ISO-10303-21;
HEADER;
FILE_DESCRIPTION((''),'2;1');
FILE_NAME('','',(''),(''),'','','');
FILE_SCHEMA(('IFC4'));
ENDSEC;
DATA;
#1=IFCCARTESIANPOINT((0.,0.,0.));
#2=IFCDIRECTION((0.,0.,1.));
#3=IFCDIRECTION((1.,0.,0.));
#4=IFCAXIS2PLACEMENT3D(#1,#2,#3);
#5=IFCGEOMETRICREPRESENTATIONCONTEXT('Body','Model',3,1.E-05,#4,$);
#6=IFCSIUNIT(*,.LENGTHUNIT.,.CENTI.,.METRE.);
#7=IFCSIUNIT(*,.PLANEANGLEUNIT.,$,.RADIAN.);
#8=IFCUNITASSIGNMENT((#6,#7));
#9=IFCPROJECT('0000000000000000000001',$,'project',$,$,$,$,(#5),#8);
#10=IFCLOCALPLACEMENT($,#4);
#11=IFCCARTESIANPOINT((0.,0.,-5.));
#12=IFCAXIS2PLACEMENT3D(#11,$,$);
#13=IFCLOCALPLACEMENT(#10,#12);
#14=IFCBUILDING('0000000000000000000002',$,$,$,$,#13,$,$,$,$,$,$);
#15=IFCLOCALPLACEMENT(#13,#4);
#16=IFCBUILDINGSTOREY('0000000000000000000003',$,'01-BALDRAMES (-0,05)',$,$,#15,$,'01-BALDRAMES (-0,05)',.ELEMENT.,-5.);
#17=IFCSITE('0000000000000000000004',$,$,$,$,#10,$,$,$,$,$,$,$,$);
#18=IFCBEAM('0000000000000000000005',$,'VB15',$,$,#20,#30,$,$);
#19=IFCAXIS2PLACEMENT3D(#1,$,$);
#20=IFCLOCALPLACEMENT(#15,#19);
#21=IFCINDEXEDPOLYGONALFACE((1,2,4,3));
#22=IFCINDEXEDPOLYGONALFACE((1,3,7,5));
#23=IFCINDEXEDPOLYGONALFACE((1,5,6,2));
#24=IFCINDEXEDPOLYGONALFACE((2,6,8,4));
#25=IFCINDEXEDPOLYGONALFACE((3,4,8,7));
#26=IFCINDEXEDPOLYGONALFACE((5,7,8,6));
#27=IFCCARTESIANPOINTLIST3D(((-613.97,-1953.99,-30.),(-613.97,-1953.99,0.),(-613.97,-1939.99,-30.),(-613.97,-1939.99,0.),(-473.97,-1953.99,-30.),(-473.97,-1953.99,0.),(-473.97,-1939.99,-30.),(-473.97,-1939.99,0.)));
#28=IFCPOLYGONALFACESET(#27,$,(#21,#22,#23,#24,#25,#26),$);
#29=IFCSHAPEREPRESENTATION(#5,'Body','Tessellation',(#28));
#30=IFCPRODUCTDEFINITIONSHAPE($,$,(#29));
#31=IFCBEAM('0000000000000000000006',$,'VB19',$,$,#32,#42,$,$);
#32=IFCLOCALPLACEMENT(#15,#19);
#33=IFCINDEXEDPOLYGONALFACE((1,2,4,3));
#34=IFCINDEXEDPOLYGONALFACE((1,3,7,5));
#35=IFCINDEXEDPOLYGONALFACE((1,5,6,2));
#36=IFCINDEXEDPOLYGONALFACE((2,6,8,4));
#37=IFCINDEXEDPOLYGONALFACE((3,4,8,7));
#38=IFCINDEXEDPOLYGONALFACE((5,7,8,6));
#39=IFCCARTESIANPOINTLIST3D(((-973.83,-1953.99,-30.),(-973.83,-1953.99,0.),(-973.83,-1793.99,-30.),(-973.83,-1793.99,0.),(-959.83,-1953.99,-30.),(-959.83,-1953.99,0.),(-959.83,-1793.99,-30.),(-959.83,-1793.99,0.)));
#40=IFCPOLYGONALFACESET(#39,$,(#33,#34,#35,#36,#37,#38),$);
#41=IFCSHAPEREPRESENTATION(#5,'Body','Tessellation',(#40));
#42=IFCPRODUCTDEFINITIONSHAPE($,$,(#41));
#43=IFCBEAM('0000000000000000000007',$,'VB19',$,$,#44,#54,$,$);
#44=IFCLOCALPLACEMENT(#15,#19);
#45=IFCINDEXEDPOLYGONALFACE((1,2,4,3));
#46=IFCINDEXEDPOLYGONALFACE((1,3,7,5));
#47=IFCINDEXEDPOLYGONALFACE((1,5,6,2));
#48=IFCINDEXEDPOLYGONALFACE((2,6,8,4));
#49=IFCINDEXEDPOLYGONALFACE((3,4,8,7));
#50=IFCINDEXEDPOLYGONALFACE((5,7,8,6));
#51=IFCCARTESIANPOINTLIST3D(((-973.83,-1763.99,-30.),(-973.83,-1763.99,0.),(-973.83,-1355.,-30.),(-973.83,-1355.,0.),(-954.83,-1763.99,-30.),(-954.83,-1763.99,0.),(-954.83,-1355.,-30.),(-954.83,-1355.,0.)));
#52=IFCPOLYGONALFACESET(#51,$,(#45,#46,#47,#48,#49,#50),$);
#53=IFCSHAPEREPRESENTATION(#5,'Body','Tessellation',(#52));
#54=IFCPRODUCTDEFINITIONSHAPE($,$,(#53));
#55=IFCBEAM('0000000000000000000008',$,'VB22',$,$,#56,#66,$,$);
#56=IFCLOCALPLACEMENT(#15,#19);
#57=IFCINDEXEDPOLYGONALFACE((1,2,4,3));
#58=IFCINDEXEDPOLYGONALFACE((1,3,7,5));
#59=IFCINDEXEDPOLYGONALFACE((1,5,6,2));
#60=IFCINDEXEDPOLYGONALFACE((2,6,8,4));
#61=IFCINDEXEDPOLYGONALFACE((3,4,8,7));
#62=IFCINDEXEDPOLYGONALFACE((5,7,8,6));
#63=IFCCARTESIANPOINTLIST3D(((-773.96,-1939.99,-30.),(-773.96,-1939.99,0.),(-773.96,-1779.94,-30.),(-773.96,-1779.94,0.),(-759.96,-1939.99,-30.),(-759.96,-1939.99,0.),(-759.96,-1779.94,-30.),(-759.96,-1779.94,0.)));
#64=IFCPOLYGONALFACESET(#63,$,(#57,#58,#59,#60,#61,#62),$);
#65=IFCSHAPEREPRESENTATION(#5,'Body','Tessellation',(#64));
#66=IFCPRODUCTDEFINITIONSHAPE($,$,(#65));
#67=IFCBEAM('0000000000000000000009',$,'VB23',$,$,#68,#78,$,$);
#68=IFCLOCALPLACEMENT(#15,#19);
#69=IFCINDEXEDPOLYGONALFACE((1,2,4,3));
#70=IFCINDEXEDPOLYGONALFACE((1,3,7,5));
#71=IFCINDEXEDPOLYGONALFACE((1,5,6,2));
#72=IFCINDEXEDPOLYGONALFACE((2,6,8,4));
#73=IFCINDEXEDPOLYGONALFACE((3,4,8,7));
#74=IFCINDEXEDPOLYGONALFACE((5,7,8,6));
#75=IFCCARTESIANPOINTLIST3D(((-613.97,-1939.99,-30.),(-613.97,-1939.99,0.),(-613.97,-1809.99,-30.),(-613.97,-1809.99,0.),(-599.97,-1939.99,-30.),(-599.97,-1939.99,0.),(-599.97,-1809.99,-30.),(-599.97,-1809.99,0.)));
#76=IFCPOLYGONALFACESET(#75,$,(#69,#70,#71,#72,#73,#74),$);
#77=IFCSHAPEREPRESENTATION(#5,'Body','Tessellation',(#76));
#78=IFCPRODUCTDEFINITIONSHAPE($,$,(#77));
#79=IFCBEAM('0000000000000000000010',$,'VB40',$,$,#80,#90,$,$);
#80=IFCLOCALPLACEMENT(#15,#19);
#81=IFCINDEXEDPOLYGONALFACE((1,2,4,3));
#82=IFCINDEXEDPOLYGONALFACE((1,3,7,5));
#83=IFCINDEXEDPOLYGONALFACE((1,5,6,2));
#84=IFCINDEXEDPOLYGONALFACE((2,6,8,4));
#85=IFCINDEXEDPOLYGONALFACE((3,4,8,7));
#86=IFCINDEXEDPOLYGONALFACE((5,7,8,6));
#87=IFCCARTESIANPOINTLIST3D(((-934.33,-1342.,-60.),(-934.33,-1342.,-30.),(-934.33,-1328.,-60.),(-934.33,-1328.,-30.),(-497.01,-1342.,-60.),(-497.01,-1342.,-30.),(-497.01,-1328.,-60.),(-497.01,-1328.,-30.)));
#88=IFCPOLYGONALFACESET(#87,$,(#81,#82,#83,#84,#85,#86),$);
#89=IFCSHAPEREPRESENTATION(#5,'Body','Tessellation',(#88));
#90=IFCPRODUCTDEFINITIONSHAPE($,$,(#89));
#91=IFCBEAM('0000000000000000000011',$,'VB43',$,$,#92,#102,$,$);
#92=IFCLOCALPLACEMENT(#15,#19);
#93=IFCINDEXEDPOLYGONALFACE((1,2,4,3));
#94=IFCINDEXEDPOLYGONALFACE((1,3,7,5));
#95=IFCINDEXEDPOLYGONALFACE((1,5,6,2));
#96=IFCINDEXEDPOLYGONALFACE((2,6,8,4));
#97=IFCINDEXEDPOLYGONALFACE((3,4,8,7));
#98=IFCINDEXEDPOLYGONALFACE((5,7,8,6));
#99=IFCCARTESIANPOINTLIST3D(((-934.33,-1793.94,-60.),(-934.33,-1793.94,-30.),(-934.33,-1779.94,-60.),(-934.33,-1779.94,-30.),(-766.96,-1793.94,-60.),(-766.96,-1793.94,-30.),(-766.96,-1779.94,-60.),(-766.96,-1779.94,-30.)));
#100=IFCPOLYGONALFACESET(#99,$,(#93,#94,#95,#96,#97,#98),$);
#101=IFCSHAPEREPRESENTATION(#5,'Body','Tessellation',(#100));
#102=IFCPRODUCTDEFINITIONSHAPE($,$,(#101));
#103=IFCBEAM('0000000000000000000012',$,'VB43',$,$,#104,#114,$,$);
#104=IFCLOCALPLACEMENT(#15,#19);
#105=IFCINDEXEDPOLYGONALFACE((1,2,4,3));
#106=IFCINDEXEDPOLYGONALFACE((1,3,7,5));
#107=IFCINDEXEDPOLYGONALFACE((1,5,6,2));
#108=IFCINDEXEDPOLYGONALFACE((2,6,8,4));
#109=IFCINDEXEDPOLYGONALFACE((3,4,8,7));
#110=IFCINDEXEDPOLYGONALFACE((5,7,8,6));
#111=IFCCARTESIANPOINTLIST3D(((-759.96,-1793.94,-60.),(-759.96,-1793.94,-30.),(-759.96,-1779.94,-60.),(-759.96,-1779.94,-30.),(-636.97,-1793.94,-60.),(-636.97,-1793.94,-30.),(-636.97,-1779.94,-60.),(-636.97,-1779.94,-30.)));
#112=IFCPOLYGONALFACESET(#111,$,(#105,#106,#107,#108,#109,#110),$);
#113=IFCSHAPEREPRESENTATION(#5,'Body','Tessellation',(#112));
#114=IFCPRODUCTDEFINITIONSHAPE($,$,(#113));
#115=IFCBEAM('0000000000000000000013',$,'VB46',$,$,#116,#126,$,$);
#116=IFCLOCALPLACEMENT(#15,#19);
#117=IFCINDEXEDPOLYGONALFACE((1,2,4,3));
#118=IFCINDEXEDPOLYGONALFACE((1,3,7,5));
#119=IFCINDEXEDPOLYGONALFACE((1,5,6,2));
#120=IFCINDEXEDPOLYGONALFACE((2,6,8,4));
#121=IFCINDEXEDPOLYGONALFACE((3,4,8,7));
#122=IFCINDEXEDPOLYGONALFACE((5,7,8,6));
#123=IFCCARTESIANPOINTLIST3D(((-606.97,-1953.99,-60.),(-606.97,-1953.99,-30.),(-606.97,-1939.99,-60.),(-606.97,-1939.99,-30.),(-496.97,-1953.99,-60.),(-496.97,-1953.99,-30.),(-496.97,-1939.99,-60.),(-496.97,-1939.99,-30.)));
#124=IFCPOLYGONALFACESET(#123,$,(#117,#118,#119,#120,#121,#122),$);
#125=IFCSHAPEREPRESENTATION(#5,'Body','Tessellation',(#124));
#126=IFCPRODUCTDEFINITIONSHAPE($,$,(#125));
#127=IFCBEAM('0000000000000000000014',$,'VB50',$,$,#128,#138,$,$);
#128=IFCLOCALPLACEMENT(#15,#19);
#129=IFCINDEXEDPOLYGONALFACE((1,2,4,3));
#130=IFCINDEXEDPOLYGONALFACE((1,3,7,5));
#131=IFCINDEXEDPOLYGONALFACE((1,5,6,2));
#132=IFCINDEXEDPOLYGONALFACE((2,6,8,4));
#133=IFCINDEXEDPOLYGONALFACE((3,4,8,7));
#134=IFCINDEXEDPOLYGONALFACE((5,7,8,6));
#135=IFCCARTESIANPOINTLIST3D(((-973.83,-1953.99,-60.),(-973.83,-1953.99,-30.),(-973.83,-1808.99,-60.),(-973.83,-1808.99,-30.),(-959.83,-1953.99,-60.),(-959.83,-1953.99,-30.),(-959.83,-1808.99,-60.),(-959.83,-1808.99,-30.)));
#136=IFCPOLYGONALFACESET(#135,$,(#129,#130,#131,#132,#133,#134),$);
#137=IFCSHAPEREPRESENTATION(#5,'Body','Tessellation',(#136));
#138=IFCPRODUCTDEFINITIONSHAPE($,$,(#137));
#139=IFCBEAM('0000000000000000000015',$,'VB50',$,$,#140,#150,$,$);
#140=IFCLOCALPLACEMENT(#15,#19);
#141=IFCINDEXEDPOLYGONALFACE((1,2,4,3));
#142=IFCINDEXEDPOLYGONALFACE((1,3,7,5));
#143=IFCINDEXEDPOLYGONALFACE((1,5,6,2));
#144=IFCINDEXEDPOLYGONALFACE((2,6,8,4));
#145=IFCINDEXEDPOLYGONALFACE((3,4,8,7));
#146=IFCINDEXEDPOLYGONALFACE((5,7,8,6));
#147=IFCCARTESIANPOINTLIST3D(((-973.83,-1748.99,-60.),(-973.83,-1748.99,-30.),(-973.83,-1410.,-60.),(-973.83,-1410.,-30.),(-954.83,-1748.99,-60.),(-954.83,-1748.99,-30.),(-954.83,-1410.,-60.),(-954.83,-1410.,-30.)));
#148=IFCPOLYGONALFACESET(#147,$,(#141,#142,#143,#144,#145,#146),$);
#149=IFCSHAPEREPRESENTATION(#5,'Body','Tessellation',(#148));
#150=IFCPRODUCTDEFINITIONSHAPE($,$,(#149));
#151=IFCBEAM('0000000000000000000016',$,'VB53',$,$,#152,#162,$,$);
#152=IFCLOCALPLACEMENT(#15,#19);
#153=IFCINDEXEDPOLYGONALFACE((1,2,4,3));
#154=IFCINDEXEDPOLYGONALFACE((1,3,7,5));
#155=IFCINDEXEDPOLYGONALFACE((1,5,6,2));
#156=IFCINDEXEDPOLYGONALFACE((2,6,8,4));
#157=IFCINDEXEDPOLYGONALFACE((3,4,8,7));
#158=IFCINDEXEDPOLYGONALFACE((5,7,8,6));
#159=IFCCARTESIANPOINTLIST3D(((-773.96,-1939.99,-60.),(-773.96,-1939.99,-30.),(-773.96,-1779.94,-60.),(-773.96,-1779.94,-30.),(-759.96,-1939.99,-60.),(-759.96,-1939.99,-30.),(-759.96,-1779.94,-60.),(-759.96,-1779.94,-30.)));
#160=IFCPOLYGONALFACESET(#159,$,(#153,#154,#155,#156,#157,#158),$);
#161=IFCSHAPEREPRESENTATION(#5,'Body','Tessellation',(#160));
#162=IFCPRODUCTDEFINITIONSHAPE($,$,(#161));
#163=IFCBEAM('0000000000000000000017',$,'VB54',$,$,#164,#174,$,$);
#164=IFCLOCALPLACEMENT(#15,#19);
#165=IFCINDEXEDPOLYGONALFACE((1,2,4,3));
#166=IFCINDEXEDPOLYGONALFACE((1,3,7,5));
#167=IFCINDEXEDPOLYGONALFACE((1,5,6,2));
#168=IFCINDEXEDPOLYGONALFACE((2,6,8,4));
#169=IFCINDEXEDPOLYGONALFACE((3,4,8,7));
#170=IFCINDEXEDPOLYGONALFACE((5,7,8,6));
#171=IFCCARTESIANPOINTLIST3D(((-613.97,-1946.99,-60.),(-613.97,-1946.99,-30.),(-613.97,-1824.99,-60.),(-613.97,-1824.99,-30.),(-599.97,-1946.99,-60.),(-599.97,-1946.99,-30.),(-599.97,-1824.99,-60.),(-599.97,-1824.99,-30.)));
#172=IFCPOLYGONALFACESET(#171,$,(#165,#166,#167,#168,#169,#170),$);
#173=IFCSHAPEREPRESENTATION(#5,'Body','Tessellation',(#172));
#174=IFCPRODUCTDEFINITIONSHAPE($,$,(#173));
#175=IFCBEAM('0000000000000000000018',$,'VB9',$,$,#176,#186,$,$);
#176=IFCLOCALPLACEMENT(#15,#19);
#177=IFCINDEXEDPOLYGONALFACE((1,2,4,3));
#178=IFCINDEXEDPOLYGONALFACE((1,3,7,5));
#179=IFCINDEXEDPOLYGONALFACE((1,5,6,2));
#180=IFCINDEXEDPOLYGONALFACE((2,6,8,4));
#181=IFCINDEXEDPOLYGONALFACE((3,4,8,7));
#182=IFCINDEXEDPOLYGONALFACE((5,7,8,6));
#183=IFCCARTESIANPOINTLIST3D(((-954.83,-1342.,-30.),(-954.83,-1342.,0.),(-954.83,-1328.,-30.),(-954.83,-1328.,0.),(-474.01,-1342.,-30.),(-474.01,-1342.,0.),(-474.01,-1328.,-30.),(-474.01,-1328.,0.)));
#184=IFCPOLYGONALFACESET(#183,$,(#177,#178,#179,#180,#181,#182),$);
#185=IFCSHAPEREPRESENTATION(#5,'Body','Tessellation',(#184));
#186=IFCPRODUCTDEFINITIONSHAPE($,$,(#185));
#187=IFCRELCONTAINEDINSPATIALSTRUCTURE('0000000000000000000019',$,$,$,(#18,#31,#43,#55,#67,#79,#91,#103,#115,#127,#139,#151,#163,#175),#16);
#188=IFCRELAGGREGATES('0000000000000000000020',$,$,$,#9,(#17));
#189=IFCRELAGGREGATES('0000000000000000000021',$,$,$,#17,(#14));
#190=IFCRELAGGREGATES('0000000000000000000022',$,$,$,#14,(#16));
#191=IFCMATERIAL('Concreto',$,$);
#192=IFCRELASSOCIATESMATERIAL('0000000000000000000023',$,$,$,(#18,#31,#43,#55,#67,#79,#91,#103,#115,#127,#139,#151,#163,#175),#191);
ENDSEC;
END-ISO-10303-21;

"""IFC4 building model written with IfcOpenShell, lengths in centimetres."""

from ifc_helpers import new_model, si_unit, frame, origin_with_axes, origin_2d_with_axis, place, context, project, spatial, rectangle, extrude, material, element, save


model = new_model("IFC4")

# Units and contexts
model_context = context("Model", 3, precision=1e-05, world=origin_with_axes(), identifier="Body")
ifc_project = project(units=[si_unit("LENGTHUNIT", "METRE", prefix="CENTI"), si_unit("PLANEANGLEUNIT", "RADIAN")], contexts=[model_context])

# Site, building, storey
site_placement = place(None, origin_with_axes())
site = spatial("IfcSite", under=ifc_project, at=site_placement)
building_placement = place(site_placement, frame((0.0, 0.0, -5.0)))
building = spatial("IfcBuilding", under=site, at=building_placement)
storey_placement = place(building_placement, origin_with_axes())
storey = spatial("IfcBuildingStorey", under=building, at=storey_placement, Name="01-BALDRAMES (-0,05)", LongName="01-BALDRAMES (-0,05)", CompositionType="ELEMENT", Elevation=-5.0)

# Shared definitions
ifc_material = material(Name="Concreto")

# Beams
beam_1_placement = place(storey_placement, frame((-543.97, -1946.99, 0.0), z_axis=(0.0, 0.0, 1.0), x_axis=(1.0, 0.0, 0.0)))
element("IfcBeam", 1, at=beam_1_placement, inside=storey, material=ifc_material, Name="VB15", context=model_context, shape_type="SolidModel", body=[
    extrude(rectangle(XDim=14.0, YDim=30.0, at=origin_2d_with_axis()), frame((-70.0, 0.0, -15.0), z_axis=(1.0, 0.0, 0.0), x_axis=(0.0, -1.0, 0.0)), (0.0, 0.0, 1.0), 140.0),
])
beam_2_placement = place(storey_placement, frame((-966.83, -1873.99, 0.0), z_axis=(0.0, 0.0, 1.0), x_axis=(1.0, 0.0, 0.0)))
element("IfcBeam", 2, at=beam_2_placement, inside=storey, material=ifc_material, Name="VB19", context=model_context, shape_type="SolidModel", body=[
    extrude(rectangle(XDim=14.0, YDim=30.0, at=origin_2d_with_axis()), frame((0.0, -80.0, -15.0), z_axis=(0.0, 1.0, 0.0), x_axis=(1.0, 0.0, 0.0)), (0.0, 0.0, 1.0), 160.0),
])
beam_3_placement = place(storey_placement, frame((-964.33, -1559.49, 0.0), z_axis=(0.0, 0.0, 1.0), x_axis=(1.0, 0.0, 0.0)))
element("IfcBeam", 3, at=beam_3_placement, inside=storey, material=ifc_material, Name="VB19", context=model_context, shape_type="SolidModel", body=[
    extrude(rectangle(XDim=19.0, YDim=30.0, at=origin_2d_with_axis()), frame((0.0, -204.5, -15.0), z_axis=(0.0, 1.0, 0.0), x_axis=(1.0, 0.0, 0.0)), (0.0, 0.0, 1.0), 408.99),
])
beam_4_placement = place(storey_placement, frame((-766.96, -1859.96, 0.0), z_axis=(0.0, 0.0, 1.0), x_axis=(1.0, 0.0, 0.0)))
element("IfcBeam", 4, at=beam_4_placement, inside=storey, material=ifc_material, Name="VB22", context=model_context, shape_type="SolidModel", body=[
    extrude(rectangle(XDim=14.0, YDim=30.0, at=origin_2d_with_axis()), frame((0.0, -80.03, -15.0), z_axis=(0.0, 1.0, 0.0), x_axis=(1.0, 0.0, 0.0)), (0.0, 0.0, 1.0), 160.05),
])
beam_5_placement = place(storey_placement, frame((-606.97, -1874.99, 0.0), z_axis=(0.0, 0.0, 1.0), x_axis=(1.0, 0.0, 0.0)))
element("IfcBeam", 5, at=beam_5_placement, inside=storey, material=ifc_material, Name="VB23", context=model_context, shape_type="SolidModel", body=[
    extrude(rectangle(XDim=14.0, YDim=30.0, at=origin_2d_with_axis()), frame((0.0, -65.0, -15.0), z_axis=(0.0, 1.0, 0.0), x_axis=(1.0, 0.0, 0.0)), (0.0, 0.0, 1.0), 130.0),
])
beam_6_placement = place(storey_placement, frame((-715.67, -1335.0, -30.0), z_axis=(0.0, 0.0, 1.0), x_axis=(1.0, 0.0, 0.0)))
element("IfcBeam", 6, at=beam_6_placement, inside=storey, material=ifc_material, Name="VB40", context=model_context, shape_type="SolidModel", body=[
    extrude(rectangle(XDim=14.0, YDim=30.0, at=origin_2d_with_axis()), frame((-218.66, 0.0, -15.0), z_axis=(1.0, 0.0, 0.0), x_axis=(0.0, -1.0, 0.0)), (0.0, 0.0, 1.0), 437.32),
])
beam_7_placement = place(storey_placement, frame((-850.64, -1786.94, -30.0), z_axis=(0.0, 0.0, 1.0), x_axis=(1.0, 0.0, 0.0)))
element("IfcBeam", 7, at=beam_7_placement, inside=storey, material=ifc_material, Name="VB43", context=model_context, shape_type="SolidModel", body=[
    extrude(rectangle(XDim=14.0, YDim=30.0, at=origin_2d_with_axis()), frame((-83.69, 0.0, -15.0), z_axis=(1.0, 0.0, 0.0), x_axis=(0.0, -1.0, 0.0)), (0.0, 0.0, 1.0), 167.37),
])
beam_8_placement = place(storey_placement, frame((-698.47, -1786.94, -30.0), z_axis=(0.0, 0.0, 1.0), x_axis=(1.0, 0.0, 0.0)))
element("IfcBeam", 8, at=beam_8_placement, inside=storey, material=ifc_material, Name="VB43", context=model_context, shape_type="SolidModel", body=[
    extrude(rectangle(XDim=14.0, YDim=30.0, at=origin_2d_with_axis()), frame((-61.49, 0.0, -15.0), z_axis=(1.0, 0.0, 0.0), x_axis=(0.0, -1.0, 0.0)), (0.0, 0.0, 1.0), 122.99),
])
beam_9_placement = place(storey_placement, frame((-551.97, -1946.99, -30.0), z_axis=(0.0, 0.0, 1.0), x_axis=(1.0, 0.0, 0.0)))
element("IfcBeam", 9, at=beam_9_placement, inside=storey, material=ifc_material, Name="VB46", context=model_context, shape_type="SolidModel", body=[
    extrude(rectangle(XDim=14.0, YDim=30.0, at=origin_2d_with_axis()), frame((-55.0, 0.0, -15.0), z_axis=(1.0, 0.0, 0.0), x_axis=(0.0, -1.0, 0.0)), (0.0, 0.0, 1.0), 110.0),
])
beam_10_placement = place(storey_placement, frame((-966.83, -1881.49, -30.0), z_axis=(0.0, 0.0, 1.0), x_axis=(1.0, 0.0, 0.0)))
element("IfcBeam", 10, at=beam_10_placement, inside=storey, material=ifc_material, Name="VB50", context=model_context, shape_type="SolidModel", body=[
    extrude(rectangle(XDim=14.0, YDim=30.0, at=origin_2d_with_axis()), frame((0.0, -72.5, -15.0), z_axis=(0.0, 1.0, 0.0), x_axis=(1.0, 0.0, 0.0)), (0.0, 0.0, 1.0), 145.0),
])
beam_11_placement = place(storey_placement, frame((-964.33, -1579.49, -30.0), z_axis=(0.0, 0.0, 1.0), x_axis=(1.0, 0.0, 0.0)))
element("IfcBeam", 11, at=beam_11_placement, inside=storey, material=ifc_material, Name="VB50", context=model_context, shape_type="SolidModel", body=[
    extrude(rectangle(XDim=19.0, YDim=30.0, at=origin_2d_with_axis()), frame((0.0, -169.5, -15.0), z_axis=(0.0, 1.0, 0.0), x_axis=(1.0, 0.0, 0.0)), (0.0, 0.0, 1.0), 338.99),
])
beam_12_placement = place(storey_placement, frame((-766.96, -1859.96, -30.0), z_axis=(0.0, 0.0, 1.0), x_axis=(1.0, 0.0, 0.0)))
element("IfcBeam", 12, at=beam_12_placement, inside=storey, material=ifc_material, Name="VB53", context=model_context, shape_type="SolidModel", body=[
    extrude(rectangle(XDim=14.0, YDim=30.0, at=origin_2d_with_axis()), frame((0.0, -80.03, -15.0), z_axis=(0.0, 1.0, 0.0), x_axis=(1.0, 0.0, 0.0)), (0.0, 0.0, 1.0), 160.05),
])
beam_13_placement = place(storey_placement, frame((-606.97, -1885.99, -30.0), z_axis=(0.0, 0.0, 1.0), x_axis=(1.0, 0.0, 0.0)))
element("IfcBeam", 13, at=beam_13_placement, inside=storey, material=ifc_material, Name="VB54", context=model_context, shape_type="SolidModel", body=[
    extrude(rectangle(XDim=14.0, YDim=30.0, at=origin_2d_with_axis()), frame((0.0, -61.0, -15.0), z_axis=(0.0, 1.0, 0.0), x_axis=(1.0, 0.0, 0.0)), (0.0, 0.0, 1.0), 122.0),
])
beam_14_placement = place(storey_placement, frame((-714.42, -1335.0, 0.0), z_axis=(0.0, 0.0, 1.0), x_axis=(1.0, 0.0, 0.0)))
element("IfcBeam", 14, at=beam_14_placement, inside=storey, material=ifc_material, Name="VB9", context=model_context, shape_type="SolidModel", body=[
    extrude(rectangle(XDim=14.0, YDim=30.0, at=origin_2d_with_axis()), frame((-240.41, 0.0, -15.0), z_axis=(1.0, 0.0, 0.0), x_axis=(0.0, -1.0, 0.0)), (0.0, 0.0, 1.0), 480.82),
])

save(model, "model.ifc")
